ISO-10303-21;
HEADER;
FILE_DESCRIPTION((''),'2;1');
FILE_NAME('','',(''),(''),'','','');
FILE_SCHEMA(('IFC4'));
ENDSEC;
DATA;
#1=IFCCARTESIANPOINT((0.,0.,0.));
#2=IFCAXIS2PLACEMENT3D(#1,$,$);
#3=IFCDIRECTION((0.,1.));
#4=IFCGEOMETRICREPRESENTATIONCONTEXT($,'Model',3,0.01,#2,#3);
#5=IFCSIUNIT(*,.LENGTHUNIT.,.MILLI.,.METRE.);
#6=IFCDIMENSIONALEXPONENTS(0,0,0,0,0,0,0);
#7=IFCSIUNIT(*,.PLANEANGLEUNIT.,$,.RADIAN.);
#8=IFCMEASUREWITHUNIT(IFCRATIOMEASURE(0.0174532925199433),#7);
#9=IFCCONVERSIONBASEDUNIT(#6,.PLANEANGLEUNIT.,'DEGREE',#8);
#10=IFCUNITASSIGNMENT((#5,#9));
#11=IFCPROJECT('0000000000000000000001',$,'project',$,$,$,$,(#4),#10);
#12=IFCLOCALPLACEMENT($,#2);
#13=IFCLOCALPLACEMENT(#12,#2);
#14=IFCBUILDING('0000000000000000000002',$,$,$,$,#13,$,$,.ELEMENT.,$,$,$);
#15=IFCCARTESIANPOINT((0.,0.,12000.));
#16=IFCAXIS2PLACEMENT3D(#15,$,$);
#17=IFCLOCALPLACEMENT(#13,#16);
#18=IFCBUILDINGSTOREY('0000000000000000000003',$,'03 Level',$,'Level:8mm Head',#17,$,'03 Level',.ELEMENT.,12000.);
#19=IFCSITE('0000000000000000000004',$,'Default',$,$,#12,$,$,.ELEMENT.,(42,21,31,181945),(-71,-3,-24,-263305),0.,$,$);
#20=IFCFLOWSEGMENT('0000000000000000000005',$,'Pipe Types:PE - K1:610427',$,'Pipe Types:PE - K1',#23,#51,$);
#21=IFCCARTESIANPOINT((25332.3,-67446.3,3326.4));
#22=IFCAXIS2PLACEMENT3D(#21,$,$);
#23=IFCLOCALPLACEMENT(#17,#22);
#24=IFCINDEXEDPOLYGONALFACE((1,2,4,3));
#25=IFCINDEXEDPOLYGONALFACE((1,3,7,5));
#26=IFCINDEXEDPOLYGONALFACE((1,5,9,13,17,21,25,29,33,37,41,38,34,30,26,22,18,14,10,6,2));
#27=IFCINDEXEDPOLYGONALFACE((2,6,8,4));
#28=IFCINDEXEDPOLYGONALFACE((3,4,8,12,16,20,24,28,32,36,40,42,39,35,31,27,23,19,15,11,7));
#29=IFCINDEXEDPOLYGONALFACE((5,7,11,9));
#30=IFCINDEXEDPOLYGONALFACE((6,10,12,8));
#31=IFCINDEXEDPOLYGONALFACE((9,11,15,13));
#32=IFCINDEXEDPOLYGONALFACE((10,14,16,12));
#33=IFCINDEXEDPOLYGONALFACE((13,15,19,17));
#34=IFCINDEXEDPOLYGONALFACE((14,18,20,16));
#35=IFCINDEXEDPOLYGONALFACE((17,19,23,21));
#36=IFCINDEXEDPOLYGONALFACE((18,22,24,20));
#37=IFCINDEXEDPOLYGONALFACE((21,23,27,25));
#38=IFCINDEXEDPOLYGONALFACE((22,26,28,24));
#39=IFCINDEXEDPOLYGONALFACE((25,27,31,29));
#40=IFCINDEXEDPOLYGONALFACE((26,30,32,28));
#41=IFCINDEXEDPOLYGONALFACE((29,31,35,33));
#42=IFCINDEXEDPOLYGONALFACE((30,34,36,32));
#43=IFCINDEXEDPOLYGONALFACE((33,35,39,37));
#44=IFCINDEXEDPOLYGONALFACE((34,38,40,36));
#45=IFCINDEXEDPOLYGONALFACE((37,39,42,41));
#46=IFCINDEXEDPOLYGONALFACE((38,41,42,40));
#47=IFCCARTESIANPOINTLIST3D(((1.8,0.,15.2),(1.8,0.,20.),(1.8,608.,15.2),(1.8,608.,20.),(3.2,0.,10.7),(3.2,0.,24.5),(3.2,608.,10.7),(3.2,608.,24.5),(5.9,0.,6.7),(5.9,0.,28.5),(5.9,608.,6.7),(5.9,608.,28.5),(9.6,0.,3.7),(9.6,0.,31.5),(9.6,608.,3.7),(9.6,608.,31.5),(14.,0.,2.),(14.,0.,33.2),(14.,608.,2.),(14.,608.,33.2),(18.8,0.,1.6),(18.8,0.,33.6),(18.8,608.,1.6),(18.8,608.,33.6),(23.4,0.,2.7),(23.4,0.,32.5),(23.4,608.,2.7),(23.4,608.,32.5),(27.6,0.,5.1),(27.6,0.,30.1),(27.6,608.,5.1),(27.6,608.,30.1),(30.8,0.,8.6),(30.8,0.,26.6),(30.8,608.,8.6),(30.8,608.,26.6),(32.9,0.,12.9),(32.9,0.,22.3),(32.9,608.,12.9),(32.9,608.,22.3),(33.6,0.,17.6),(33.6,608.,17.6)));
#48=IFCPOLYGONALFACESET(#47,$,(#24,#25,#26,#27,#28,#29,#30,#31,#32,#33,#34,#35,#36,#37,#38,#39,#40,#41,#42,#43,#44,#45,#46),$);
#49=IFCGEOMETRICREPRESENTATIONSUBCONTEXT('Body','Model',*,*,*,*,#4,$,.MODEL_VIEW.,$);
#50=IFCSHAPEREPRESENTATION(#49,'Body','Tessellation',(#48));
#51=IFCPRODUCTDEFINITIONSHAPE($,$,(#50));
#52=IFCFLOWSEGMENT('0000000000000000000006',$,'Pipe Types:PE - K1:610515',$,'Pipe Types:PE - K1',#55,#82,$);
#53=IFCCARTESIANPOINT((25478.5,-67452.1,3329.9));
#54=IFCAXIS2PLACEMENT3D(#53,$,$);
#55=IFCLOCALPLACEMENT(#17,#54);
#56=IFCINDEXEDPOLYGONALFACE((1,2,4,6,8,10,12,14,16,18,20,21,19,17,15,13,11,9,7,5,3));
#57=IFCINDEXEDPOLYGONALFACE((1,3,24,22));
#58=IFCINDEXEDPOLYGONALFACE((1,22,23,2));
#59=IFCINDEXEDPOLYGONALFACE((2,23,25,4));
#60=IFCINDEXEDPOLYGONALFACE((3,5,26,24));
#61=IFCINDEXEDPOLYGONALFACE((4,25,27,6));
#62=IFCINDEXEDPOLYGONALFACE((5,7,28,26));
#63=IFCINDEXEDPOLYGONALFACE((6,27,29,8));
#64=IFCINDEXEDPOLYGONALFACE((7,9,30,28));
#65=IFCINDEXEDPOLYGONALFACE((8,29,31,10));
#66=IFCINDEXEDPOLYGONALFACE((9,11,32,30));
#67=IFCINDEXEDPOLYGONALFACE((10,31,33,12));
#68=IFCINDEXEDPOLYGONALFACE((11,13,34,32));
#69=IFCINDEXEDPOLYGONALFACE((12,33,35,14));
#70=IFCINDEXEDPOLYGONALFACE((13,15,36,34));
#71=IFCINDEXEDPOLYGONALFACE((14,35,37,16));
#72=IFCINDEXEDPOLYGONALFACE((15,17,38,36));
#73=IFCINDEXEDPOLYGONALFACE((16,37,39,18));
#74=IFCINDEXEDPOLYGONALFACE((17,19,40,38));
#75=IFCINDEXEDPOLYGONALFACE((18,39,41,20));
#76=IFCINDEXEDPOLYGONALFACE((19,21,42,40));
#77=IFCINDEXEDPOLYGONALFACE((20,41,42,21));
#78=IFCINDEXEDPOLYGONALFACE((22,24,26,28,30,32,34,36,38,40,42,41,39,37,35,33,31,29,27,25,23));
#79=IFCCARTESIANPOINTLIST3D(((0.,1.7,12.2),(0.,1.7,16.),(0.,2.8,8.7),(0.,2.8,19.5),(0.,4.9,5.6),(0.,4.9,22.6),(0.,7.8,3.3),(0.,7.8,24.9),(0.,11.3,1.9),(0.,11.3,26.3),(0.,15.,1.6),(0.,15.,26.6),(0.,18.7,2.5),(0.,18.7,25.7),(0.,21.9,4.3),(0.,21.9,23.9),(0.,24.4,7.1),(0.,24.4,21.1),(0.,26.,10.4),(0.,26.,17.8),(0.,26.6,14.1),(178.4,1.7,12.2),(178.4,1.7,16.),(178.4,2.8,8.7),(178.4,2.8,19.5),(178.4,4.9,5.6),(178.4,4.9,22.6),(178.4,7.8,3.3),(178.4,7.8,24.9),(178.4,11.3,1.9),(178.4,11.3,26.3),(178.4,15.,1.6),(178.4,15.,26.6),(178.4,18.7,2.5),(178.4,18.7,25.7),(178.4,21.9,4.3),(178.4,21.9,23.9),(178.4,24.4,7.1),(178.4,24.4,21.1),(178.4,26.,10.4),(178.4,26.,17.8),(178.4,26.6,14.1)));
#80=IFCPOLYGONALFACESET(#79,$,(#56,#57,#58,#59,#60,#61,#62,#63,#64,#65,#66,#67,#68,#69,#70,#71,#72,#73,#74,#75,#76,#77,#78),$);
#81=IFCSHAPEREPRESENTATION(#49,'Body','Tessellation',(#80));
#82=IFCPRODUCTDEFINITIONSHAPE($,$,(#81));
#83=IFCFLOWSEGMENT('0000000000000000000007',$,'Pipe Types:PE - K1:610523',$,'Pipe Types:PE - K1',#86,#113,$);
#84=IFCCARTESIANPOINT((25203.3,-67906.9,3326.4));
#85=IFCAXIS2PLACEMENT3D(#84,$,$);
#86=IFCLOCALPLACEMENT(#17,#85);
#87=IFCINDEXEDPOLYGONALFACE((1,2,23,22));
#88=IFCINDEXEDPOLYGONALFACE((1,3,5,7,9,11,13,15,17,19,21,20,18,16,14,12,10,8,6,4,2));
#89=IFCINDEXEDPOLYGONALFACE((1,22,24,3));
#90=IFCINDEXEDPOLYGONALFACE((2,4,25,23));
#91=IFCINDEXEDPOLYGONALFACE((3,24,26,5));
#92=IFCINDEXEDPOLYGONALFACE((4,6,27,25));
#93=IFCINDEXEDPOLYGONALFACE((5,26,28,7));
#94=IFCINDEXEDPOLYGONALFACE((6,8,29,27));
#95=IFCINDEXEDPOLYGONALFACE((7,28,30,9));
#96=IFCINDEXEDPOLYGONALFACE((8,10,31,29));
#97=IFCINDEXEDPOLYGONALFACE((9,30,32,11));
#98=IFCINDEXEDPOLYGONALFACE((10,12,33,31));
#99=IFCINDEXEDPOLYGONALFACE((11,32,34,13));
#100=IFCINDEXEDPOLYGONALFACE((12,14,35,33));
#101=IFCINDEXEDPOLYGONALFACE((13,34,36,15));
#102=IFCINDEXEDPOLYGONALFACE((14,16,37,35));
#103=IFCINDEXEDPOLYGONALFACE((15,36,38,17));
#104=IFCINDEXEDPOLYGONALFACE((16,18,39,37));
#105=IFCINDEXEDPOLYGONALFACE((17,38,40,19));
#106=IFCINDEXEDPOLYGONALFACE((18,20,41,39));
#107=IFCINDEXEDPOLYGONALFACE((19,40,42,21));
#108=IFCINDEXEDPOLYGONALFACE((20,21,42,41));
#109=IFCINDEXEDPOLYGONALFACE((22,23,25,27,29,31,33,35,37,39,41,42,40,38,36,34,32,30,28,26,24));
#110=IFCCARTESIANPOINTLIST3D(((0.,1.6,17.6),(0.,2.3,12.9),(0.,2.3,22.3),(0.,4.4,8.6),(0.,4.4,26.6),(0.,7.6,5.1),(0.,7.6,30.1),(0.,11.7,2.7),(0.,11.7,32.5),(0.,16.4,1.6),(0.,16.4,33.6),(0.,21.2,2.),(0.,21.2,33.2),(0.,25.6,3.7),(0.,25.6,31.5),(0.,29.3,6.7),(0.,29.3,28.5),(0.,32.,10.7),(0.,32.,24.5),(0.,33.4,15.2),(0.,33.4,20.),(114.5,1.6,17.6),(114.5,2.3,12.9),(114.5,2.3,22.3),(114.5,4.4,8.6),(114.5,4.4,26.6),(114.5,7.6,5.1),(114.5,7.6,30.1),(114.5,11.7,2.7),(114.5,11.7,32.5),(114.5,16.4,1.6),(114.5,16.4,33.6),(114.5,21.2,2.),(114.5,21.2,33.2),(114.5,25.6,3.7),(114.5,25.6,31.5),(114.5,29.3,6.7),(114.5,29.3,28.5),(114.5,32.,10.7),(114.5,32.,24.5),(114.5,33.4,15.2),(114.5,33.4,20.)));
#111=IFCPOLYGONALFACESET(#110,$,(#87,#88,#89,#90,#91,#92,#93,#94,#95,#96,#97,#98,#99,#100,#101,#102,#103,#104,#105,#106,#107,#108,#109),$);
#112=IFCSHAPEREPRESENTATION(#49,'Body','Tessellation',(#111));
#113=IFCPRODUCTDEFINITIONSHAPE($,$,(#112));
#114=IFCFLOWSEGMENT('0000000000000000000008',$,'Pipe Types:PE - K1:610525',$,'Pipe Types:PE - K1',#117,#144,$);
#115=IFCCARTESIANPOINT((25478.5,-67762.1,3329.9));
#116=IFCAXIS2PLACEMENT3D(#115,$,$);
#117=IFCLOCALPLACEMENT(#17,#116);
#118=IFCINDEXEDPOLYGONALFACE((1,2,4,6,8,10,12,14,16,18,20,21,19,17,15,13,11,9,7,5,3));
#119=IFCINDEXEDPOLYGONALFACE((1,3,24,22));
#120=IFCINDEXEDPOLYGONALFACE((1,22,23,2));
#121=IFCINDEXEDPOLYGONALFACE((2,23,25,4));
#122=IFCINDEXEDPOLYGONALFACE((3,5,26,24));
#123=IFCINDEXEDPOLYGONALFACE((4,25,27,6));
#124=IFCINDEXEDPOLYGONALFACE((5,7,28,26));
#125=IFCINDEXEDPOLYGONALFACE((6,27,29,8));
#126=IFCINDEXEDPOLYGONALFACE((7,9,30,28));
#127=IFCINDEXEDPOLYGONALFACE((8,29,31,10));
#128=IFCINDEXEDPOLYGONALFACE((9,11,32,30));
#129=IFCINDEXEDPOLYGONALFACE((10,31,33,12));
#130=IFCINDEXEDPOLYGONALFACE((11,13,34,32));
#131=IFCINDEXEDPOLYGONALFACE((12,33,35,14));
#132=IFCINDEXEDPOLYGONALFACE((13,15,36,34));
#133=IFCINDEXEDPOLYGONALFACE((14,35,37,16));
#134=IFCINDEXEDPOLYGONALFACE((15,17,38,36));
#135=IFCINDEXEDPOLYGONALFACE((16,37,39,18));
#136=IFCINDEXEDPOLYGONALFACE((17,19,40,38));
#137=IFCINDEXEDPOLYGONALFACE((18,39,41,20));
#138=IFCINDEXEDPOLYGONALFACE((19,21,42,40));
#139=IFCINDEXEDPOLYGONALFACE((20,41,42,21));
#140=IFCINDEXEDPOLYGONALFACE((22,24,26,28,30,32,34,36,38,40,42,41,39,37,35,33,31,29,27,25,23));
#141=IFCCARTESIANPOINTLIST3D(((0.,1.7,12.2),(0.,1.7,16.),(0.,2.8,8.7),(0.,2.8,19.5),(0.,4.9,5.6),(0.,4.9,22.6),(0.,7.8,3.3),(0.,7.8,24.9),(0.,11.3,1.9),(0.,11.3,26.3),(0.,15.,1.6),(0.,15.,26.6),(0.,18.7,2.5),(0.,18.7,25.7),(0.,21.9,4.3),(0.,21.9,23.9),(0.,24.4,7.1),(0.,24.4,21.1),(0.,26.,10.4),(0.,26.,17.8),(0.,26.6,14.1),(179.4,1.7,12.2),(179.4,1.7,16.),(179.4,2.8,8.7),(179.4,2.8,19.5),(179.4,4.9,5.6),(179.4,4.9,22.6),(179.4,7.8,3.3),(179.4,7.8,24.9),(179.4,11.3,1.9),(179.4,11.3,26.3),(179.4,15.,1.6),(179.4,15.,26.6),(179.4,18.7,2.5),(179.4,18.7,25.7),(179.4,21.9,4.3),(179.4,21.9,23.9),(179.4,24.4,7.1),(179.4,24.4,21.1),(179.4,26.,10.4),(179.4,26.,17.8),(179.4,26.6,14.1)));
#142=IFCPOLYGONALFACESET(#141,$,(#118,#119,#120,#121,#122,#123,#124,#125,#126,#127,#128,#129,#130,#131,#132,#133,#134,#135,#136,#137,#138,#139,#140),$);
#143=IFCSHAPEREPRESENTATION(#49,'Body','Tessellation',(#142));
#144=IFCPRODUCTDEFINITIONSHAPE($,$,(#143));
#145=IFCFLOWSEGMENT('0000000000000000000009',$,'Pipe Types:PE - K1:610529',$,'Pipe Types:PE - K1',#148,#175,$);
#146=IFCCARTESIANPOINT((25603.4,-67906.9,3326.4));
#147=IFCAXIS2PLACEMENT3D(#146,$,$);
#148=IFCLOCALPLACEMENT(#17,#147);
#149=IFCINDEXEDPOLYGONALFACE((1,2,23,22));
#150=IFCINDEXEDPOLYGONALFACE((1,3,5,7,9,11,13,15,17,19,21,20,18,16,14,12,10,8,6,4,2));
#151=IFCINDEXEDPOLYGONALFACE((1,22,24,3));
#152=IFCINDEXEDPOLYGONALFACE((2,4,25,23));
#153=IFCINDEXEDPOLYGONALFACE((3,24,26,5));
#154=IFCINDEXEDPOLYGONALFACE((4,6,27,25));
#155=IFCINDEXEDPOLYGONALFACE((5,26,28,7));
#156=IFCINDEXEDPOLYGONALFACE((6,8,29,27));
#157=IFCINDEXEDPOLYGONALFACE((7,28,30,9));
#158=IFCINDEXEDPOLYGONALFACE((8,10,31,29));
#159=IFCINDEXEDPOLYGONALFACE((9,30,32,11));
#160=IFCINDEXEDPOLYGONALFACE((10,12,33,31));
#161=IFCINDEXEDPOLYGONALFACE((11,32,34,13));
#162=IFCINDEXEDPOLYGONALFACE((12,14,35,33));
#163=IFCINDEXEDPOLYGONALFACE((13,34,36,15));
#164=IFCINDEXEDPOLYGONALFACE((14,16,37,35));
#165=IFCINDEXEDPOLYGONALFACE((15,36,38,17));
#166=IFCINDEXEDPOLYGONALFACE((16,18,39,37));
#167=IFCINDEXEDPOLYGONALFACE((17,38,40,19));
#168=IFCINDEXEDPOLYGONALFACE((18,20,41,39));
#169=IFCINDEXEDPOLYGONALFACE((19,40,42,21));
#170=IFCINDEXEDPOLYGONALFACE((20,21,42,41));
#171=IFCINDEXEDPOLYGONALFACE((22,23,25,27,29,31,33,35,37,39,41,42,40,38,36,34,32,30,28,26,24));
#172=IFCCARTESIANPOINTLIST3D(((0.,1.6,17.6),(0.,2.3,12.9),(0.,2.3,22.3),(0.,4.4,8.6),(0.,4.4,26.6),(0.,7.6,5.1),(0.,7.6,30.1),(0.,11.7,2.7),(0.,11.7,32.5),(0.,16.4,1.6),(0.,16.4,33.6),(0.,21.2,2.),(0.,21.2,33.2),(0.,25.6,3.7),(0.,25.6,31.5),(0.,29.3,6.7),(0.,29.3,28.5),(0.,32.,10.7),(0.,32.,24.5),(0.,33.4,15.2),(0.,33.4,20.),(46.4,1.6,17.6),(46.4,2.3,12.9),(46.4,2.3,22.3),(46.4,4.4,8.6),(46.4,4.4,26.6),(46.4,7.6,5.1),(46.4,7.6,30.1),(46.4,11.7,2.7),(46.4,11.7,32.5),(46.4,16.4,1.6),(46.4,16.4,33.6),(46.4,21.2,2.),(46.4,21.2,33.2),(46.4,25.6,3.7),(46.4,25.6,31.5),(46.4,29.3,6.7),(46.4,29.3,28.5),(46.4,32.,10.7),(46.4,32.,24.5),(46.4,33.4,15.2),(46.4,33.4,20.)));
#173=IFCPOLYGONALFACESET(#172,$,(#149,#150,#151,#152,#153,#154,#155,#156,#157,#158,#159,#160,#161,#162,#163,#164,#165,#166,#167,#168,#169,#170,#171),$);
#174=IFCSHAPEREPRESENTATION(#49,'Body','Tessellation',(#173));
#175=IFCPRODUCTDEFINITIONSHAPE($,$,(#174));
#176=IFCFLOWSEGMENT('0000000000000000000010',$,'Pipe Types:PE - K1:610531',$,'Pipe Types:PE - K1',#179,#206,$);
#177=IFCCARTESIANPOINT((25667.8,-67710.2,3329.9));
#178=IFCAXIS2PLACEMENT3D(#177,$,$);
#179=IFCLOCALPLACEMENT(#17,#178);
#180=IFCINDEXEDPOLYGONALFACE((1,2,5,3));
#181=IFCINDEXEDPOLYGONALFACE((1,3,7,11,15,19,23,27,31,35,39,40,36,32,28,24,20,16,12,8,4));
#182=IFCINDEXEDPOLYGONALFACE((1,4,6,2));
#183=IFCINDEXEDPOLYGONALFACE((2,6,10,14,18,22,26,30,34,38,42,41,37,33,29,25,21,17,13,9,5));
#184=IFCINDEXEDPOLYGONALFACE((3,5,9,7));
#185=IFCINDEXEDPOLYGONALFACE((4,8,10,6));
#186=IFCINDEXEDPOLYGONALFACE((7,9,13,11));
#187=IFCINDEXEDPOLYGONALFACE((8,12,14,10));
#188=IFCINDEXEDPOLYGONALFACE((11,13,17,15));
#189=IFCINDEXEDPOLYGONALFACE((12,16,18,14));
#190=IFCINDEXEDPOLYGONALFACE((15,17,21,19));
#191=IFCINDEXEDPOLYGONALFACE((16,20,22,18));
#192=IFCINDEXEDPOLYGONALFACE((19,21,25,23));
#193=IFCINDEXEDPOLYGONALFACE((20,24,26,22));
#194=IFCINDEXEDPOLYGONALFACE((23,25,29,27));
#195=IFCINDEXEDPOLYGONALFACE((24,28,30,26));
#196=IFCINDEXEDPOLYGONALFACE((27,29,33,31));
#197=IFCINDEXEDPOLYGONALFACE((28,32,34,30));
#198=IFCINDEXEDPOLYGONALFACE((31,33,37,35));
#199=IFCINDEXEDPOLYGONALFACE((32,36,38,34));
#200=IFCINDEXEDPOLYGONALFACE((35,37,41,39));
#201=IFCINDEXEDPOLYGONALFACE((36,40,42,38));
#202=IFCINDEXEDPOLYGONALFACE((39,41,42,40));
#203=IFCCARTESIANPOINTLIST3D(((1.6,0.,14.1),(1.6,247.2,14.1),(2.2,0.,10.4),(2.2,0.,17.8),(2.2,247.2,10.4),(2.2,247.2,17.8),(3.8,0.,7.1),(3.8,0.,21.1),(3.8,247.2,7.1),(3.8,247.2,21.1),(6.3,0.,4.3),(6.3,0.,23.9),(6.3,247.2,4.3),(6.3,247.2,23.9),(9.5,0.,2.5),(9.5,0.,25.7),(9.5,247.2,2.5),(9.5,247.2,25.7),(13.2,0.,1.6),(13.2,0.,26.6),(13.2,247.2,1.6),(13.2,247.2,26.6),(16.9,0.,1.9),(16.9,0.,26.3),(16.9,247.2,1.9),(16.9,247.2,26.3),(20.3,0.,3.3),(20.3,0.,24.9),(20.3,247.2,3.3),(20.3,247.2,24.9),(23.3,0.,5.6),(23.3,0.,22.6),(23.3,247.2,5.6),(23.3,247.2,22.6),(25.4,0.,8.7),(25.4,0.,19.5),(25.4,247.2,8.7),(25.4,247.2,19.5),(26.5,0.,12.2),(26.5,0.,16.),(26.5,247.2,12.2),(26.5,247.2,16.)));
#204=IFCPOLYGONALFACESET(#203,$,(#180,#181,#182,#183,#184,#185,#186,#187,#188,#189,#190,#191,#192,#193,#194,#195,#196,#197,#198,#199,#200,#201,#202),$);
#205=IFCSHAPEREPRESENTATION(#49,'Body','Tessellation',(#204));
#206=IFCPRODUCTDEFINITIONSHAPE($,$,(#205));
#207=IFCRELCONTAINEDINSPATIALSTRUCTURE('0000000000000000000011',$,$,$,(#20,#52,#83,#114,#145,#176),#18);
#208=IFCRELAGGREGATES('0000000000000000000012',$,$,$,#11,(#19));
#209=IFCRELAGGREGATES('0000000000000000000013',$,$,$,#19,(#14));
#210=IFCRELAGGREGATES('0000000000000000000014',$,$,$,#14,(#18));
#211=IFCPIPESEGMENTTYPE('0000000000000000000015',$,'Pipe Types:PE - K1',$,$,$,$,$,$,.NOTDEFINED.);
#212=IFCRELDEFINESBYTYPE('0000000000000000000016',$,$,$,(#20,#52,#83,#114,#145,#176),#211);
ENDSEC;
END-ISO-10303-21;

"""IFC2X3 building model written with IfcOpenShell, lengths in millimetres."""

from ifc_helpers import new_model, entity, si_unit, converted_unit, direction, frame, frame_2d, origin, origin_2d_with_axis, place, context, subcontext, project, spatial, circle, extrude, type_object, element, save


model = new_model("IFC2X3")

# Units and contexts
model_context = context("Model", 3, precision=0.01, world=origin(), true_north=direction((0.0, 1.0)))
body_context = subcontext(model_context, "Body", "Model", "MODEL_VIEW")
ifc_project = project(units=[si_unit("LENGTHUNIT", "METRE", prefix="MILLI"), converted_unit("PLANEANGLEUNIT", "DEGREE", entity("IfcRatioMeasure", 0.0174532925199433), si_unit("PLANEANGLEUNIT", "RADIAN"), dimensions=[0, 0, 0, 0, 0, 0, 0])], contexts=[model_context])

# Site, building, storey
site_placement = place(None, origin())
site = spatial("IfcSite", under=ifc_project, at=site_placement, Name="Default", CompositionType="ELEMENT", RefLatitude=(42, 21, 31, 181945), RefLongitude=(-71, -3, -24, -263305), RefElevation=0.0)
building_placement = place(site_placement, origin())
building = spatial("IfcBuilding", under=site, at=building_placement, CompositionType="ELEMENT")
storey_placement = place(building_placement, frame((0.0, 0.0, 12000.0)))
storey = spatial("IfcBuildingStorey", under=building, at=storey_placement, Name="03 Level", ObjectType="Level:8mm Head", LongName="03 Level", CompositionType="ELEMENT", Elevation=12000.0)

# Flow segments
pipe_segment_type = type_object("IfcPipeSegmentType", Name="Pipe Types:PE - K1", PredefinedType="NOTDEFINED")
flow_segment_1_placement = place(storey_placement, frame((25332.3, -67446.3, 3326.4)))
element("IfcFlowSegment", 1, at=flow_segment_1_placement, inside=storey, type_object=pipe_segment_type, Name="Pipe Types:PE - K1:610427", ObjectType="Pipe Types:PE - K1", context=body_context, shape_type="SweptSolid", body=[
    extrude(circle(Radius=16.0, at=origin_2d_with_axis()), frame((17.6, 0.0, 17.6), z_axis=(0.0, 1.0, 0.0), x_axis=(1.0, 0.0, 0.0)), (0.0, 0.0, 1.0), 608.0),
])
flow_segment_2_placement = place(storey_placement, frame((25478.5, -67452.1, 3329.9)))
element("IfcFlowSegment", 2, at=flow_segment_2_placement, inside=storey, type_object=pipe_segment_type, Name="Pipe Types:PE - K1:610515", ObjectType="Pipe Types:PE - K1", context=body_context, shape_type="SweptSolid", body=[
    extrude(circle(Radius=12.5, at=frame_2d((0.0, 0.0), x_axis=(1.0, 0.0))), frame((0.0, 14.1, 14.1), z_axis=(1.0, 0.0, 0.0), x_axis=(0.0, 1.0, 0.0)), (0.0, 0.0, 1.0), 178.4),
])
flow_segment_3_placement = place(storey_placement, frame((25203.3, -67906.9, 3326.4)))
element("IfcFlowSegment", 3, at=flow_segment_3_placement, inside=storey, type_object=pipe_segment_type, Name="Pipe Types:PE - K1:610523", ObjectType="Pipe Types:PE - K1", context=body_context, shape_type="SweptSolid", body=[
    extrude(circle(Radius=16.0, at=origin_2d_with_axis()), frame((0.0, 17.6, 17.6), z_axis=(1.0, 0.0, 0.0), x_axis=(0.0, -1.0, 0.0)), (0.0, 0.0, 1.0), 114.5),
])
flow_segment_4_placement = place(storey_placement, frame((25478.5, -67762.1, 3329.9)))
element("IfcFlowSegment", 4, at=flow_segment_4_placement, inside=storey, type_object=pipe_segment_type, Name="Pipe Types:PE - K1:610525", ObjectType="Pipe Types:PE - K1", context=body_context, shape_type="SweptSolid", body=[
    extrude(circle(Radius=12.5, at=frame_2d((0.0, 0.0), x_axis=(1.0, 0.0))), frame((0.0, 14.1, 14.1), z_axis=(1.0, 0.0, 0.0), x_axis=(0.0, 1.0, 0.0)), (0.0, 0.0, 1.0), 179.4),
])
flow_segment_5_placement = place(storey_placement, frame((25603.4, -67906.9, 3326.4)))
element("IfcFlowSegment", 5, at=flow_segment_5_placement, inside=storey, type_object=pipe_segment_type, Name="Pipe Types:PE - K1:610529", ObjectType="Pipe Types:PE - K1", context=body_context, shape_type="SweptSolid", body=[
    extrude(circle(Radius=16.0, at=origin_2d_with_axis()), frame((0.0, 17.6, 17.6), z_axis=(1.0, 0.0, 0.0), x_axis=(0.0, -1.0, 0.0)), (0.0, 0.0, 1.0), 46.4),
])
flow_segment_6_placement = place(storey_placement, frame((25667.8, -67710.2, 3329.9)))
element("IfcFlowSegment", 6, at=flow_segment_6_placement, inside=storey, type_object=pipe_segment_type, Name="Pipe Types:PE - K1:610531", ObjectType="Pipe Types:PE - K1", context=body_context, shape_type="SweptSolid", body=[
    extrude(circle(Radius=12.5, at=frame_2d((0.0, 0.0), x_axis=(1.0, 0.0))), frame((14.1, 0.0, 14.1), z_axis=(0.0, 1.0, 0.0), x_axis=(-1.0, 0.0, 0.0)), (0.0, 0.0, 1.0), 247.2),
])

save(model, "model.ifc")
